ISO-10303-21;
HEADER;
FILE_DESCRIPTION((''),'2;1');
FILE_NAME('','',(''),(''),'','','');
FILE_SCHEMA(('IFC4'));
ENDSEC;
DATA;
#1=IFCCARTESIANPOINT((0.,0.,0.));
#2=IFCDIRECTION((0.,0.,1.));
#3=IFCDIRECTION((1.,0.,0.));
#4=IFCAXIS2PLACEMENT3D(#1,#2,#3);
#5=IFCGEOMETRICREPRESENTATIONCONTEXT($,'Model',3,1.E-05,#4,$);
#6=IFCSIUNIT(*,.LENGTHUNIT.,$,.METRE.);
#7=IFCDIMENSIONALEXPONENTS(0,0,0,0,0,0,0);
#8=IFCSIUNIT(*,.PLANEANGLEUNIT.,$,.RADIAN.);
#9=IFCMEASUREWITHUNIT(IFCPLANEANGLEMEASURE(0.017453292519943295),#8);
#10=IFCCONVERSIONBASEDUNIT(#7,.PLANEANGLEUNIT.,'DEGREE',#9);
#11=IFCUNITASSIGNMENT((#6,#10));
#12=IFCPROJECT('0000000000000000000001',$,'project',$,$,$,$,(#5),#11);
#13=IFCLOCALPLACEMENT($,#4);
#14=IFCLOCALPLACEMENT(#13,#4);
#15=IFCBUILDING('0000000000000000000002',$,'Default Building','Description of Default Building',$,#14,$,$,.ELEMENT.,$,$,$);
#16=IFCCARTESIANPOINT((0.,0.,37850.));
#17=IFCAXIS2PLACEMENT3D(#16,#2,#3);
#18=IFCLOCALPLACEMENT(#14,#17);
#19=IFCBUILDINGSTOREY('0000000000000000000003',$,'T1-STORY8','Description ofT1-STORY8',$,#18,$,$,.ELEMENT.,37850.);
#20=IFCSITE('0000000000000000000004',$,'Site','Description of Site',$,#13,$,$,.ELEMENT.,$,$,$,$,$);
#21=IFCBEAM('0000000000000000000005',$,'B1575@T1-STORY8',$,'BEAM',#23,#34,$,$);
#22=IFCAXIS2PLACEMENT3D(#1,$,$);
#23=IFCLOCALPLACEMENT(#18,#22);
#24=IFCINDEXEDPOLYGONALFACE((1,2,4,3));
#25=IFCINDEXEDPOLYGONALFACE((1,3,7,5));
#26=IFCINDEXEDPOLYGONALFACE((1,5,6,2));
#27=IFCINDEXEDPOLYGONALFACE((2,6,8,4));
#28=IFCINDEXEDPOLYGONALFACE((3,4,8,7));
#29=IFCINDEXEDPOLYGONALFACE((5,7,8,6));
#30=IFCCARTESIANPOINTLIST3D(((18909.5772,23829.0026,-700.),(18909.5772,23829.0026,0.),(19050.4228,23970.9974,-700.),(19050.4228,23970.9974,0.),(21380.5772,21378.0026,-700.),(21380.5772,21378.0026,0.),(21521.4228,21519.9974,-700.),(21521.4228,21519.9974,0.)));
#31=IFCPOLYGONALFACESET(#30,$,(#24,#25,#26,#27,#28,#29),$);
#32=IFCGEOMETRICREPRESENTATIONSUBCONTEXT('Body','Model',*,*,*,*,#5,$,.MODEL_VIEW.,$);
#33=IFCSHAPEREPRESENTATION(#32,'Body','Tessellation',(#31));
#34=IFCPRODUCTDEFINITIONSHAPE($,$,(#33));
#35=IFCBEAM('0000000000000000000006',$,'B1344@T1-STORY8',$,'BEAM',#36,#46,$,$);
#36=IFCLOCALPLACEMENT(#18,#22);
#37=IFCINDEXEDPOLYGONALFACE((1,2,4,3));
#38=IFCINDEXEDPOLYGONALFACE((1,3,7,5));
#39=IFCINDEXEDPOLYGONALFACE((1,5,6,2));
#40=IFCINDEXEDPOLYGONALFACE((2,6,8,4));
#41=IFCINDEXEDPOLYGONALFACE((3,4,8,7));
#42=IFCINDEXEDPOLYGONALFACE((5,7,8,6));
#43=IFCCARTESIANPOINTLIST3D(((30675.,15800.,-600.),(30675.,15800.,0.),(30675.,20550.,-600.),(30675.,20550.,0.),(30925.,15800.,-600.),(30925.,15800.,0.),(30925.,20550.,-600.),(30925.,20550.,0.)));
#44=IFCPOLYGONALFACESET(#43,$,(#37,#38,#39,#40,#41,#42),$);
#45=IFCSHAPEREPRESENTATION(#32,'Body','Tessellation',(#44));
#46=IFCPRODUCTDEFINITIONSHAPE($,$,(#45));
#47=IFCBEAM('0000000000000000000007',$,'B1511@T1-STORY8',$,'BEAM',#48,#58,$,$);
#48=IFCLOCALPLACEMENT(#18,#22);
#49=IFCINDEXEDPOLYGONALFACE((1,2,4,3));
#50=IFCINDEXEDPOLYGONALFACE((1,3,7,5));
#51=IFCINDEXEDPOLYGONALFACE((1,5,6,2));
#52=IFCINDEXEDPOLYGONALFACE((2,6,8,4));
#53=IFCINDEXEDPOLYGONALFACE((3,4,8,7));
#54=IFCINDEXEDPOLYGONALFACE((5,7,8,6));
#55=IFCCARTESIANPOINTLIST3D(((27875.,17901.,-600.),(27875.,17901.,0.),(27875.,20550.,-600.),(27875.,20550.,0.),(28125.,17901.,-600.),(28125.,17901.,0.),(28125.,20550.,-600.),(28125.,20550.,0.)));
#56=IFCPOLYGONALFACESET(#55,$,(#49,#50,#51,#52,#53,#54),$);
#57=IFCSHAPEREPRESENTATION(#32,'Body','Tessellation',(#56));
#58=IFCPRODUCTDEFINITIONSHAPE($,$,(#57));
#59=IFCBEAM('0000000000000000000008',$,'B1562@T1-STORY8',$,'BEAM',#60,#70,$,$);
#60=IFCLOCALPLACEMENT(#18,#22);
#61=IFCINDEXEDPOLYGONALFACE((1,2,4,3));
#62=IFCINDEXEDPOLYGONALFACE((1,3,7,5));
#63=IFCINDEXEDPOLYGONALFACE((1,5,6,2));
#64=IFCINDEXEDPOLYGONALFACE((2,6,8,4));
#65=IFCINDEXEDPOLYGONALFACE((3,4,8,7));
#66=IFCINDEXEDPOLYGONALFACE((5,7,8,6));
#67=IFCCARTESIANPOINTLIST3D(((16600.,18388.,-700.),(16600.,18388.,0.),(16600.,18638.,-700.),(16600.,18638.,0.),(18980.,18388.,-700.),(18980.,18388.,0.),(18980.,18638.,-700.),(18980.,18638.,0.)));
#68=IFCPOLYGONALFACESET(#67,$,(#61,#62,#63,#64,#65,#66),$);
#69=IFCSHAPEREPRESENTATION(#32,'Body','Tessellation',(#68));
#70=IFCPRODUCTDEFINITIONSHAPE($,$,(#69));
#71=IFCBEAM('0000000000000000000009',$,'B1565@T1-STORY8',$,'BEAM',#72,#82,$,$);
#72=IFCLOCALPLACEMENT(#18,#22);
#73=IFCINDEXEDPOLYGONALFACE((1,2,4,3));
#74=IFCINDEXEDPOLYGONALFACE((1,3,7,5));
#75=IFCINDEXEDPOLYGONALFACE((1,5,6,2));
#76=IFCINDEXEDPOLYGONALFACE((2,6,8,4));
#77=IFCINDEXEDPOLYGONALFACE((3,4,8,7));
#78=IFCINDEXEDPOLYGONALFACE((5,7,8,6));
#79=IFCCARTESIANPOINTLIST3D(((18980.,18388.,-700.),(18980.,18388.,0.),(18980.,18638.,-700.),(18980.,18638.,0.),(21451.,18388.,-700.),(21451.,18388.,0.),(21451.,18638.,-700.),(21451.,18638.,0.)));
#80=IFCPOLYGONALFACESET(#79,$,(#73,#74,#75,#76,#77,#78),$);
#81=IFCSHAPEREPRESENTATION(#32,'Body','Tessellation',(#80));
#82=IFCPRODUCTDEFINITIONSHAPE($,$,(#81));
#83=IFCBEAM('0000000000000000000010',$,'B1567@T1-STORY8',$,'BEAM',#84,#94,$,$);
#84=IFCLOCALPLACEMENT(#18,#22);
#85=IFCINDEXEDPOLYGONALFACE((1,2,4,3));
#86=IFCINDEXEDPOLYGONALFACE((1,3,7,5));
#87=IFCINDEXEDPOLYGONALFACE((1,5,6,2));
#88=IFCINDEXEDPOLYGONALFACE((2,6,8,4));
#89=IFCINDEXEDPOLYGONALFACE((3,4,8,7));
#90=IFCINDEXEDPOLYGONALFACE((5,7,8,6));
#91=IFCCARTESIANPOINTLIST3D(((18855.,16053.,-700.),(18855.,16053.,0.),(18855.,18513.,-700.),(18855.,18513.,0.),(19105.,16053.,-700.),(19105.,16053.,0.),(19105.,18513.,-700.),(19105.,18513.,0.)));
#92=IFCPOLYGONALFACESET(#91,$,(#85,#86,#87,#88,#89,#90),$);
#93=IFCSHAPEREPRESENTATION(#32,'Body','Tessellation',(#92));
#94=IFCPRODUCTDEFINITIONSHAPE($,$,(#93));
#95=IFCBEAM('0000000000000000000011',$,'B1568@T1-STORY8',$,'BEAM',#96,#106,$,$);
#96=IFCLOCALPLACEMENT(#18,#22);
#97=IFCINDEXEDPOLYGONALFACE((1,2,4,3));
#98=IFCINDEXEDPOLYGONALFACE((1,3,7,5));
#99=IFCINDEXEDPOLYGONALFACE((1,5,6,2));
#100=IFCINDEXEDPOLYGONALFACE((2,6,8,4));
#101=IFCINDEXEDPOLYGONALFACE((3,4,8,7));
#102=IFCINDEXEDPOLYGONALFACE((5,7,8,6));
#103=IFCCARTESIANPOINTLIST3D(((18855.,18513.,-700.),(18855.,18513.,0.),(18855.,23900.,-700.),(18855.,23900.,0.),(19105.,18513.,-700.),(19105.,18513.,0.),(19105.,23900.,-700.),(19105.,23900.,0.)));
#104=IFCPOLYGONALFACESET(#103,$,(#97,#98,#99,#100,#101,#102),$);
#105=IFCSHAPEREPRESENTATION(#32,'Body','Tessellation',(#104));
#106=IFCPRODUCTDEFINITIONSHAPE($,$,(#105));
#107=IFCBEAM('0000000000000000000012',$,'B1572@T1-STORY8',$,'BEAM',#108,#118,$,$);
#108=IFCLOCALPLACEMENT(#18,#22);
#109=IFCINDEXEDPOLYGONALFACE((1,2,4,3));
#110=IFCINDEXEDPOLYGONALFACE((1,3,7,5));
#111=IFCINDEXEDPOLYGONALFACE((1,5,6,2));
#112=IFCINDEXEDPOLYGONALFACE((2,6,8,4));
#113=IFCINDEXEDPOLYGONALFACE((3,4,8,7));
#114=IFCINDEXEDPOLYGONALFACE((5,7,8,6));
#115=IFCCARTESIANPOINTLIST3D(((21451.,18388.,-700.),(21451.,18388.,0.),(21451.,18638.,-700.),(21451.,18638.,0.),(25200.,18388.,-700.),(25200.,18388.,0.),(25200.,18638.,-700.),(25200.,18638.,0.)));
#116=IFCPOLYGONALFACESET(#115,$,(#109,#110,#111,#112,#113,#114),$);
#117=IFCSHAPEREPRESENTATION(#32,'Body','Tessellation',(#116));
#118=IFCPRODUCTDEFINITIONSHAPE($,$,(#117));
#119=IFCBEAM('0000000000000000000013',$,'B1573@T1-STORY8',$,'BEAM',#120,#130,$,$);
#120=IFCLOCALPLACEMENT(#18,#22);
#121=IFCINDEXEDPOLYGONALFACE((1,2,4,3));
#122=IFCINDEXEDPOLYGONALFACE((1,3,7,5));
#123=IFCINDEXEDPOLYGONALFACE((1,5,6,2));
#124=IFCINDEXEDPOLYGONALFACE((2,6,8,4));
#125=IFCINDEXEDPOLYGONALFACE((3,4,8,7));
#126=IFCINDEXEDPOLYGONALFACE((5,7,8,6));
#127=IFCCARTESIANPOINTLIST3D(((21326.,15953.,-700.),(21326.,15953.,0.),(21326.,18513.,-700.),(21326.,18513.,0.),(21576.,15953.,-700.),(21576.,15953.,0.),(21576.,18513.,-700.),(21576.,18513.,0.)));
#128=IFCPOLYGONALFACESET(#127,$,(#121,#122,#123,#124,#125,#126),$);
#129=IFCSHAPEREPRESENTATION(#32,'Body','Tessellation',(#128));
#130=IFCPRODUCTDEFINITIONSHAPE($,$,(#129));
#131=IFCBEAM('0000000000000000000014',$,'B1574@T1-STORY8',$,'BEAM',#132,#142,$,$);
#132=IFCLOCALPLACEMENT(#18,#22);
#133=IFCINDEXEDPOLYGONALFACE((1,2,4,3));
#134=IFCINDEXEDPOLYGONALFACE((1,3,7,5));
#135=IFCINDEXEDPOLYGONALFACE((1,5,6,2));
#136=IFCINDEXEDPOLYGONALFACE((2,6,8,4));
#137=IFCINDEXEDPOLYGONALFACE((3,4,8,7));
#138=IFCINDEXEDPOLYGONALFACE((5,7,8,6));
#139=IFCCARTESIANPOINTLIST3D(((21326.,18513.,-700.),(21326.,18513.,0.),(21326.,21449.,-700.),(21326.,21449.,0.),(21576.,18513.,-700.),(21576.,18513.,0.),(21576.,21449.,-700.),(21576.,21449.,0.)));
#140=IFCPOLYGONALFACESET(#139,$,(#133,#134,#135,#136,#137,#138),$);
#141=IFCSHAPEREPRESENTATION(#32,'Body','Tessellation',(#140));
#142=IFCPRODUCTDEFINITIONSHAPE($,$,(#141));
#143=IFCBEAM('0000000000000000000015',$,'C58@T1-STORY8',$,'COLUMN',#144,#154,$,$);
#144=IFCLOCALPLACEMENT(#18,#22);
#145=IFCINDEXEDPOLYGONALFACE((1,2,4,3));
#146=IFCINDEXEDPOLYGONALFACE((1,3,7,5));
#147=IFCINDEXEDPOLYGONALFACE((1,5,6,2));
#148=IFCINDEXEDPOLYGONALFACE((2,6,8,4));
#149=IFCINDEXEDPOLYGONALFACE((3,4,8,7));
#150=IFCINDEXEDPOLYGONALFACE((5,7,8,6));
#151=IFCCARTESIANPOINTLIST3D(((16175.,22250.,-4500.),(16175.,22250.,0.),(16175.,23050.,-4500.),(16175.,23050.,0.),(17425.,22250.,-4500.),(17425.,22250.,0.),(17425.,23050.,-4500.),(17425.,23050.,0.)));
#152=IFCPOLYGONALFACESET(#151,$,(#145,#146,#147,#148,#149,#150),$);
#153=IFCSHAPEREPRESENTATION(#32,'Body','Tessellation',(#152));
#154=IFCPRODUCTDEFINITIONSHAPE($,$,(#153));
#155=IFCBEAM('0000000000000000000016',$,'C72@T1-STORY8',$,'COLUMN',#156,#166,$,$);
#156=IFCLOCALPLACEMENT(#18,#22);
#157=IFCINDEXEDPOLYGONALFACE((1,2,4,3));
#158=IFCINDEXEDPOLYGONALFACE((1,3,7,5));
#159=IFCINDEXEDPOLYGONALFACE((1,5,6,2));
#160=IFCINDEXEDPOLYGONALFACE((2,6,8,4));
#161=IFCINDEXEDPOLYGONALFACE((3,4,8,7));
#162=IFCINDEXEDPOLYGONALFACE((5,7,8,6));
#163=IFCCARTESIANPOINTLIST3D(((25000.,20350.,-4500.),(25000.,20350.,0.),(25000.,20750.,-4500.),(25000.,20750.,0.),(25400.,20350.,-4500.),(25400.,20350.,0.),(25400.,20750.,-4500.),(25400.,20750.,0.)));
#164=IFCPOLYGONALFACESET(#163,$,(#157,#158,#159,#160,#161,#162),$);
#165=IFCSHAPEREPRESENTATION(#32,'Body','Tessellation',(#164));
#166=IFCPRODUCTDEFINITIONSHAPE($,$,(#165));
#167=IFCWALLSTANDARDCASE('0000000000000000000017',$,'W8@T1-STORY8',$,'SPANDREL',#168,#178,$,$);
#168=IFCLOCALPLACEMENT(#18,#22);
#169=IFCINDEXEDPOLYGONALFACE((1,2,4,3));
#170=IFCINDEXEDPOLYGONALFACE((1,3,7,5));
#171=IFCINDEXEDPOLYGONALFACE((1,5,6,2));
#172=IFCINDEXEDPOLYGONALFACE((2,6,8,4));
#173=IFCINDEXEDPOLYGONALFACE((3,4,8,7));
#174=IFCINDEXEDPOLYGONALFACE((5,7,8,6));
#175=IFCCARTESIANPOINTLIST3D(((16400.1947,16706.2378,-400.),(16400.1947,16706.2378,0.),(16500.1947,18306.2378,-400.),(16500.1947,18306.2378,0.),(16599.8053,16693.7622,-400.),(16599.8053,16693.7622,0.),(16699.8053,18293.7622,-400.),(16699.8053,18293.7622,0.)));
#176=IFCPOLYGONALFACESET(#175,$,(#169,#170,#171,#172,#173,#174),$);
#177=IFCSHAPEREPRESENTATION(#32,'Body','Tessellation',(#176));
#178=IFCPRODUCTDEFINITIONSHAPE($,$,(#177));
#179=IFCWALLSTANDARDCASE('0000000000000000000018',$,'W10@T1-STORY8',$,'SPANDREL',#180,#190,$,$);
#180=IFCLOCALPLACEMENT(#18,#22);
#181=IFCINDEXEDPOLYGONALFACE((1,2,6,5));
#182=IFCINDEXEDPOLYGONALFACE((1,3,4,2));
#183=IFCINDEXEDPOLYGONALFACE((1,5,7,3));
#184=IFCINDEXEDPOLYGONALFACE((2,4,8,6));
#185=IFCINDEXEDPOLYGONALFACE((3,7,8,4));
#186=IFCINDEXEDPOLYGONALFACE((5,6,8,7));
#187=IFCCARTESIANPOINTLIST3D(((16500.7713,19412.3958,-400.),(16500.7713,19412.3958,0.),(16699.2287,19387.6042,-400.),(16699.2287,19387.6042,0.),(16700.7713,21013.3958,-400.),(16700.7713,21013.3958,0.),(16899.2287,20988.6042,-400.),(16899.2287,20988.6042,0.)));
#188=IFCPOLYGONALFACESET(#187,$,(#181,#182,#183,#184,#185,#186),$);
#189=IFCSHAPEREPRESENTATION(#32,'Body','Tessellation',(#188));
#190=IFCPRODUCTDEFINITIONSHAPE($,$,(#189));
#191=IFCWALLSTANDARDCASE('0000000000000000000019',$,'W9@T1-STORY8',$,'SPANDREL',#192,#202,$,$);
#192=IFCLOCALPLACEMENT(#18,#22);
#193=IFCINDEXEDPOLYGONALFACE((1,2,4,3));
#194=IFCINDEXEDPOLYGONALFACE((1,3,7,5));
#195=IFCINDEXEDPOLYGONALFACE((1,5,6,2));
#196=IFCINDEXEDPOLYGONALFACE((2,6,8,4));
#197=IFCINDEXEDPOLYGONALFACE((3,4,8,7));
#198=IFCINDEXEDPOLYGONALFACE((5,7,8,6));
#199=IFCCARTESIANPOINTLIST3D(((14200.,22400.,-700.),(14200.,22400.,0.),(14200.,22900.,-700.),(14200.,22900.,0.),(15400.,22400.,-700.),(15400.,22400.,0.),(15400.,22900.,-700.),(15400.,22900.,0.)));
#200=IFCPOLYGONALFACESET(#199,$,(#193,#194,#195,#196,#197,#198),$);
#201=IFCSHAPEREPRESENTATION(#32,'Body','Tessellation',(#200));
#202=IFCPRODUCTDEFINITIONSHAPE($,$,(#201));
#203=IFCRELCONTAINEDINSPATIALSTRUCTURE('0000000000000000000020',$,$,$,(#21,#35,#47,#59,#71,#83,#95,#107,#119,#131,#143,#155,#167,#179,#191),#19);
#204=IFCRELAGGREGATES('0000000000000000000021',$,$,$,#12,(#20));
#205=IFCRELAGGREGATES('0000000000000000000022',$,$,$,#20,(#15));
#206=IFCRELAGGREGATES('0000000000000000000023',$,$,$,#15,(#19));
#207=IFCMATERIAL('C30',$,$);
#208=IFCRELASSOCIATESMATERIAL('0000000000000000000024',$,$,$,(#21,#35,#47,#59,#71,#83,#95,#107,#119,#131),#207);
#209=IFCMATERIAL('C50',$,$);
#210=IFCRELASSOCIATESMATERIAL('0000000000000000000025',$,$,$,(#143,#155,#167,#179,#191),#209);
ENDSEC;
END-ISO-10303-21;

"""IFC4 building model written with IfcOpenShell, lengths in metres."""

from ifc_helpers import new_model, entity, si_unit, converted_unit, frame, origin_with_axes, place, context, subcontext, project, spatial, indexed_curve, rectangle, outline, extrude, material, element, save


model = new_model("IFC4")

# Units and contexts
model_context = context("Model", 3, precision=1e-05, world=origin_with_axes())
body_context = subcontext(model_context, "Body", "Model", "MODEL_VIEW")
ifc_project = project(units=[si_unit("LENGTHUNIT", "METRE"), converted_unit("PLANEANGLEUNIT", "DEGREE", entity("IfcPlaneAngleMeasure", 0.017453292519943295), si_unit("PLANEANGLEUNIT", "RADIAN"), dimensions=[0, 0, 0, 0, 0, 0, 0])], contexts=[model_context])

# Site, building, storey
site_placement = place(None, origin_with_axes())
site = spatial("IfcSite", under=ifc_project, at=site_placement, Name="Site", Description="Description of Site", CompositionType="ELEMENT")
building_placement = place(site_placement, origin_with_axes())
building = spatial("IfcBuilding", under=site, at=building_placement, Name="Default Building", Description="Description of Default Building", CompositionType="ELEMENT")
storey_placement = place(building_placement, frame((0.0, 0.0, 37850.0), z_axis=(0.0, 0.0, 1.0), x_axis=(1.0, 0.0, 0.0)))
storey = spatial("IfcBuildingStorey", under=building, at=storey_placement, Name="T1-STORY8", Description="Description ofT1-STORY8", CompositionType="ELEMENT", Elevation=37850.0)

# Beams
ifc_material_1 = material(Name="C30")
beam_1_placement = place(storey_placement, frame((18980.0, 23900.0, -350.0), z_axis=(0.709974, -0.704228, 0.0), x_axis=(0.704228, 0.709974, 0.0)))
element("IfcBeam", 1, at=beam_1_placement, inside=storey, material=ifc_material_1, Name="B1575@T1-STORY8", ObjectType="BEAM", context=body_context, shape_type="SweptSolid", body=[
    extrude(rectangle(XDim=200.0, YDim=700.0), origin_with_axes(), (0.0, 0.0, 1.0), 3480.4083),
])
beam_2_placement = place(storey_placement, frame((30800.0, 15800.0, -300.0), z_axis=(0.0, 1.0, 0.0), x_axis=(-1.0, 0.0, 0.0)))
element("IfcBeam", 2, at=beam_2_placement, inside=storey, material=ifc_material_1, Name="B1344@T1-STORY8", ObjectType="BEAM", context=body_context, shape_type="SweptSolid", body=[
    extrude(rectangle(XDim=250.0, YDim=600.0), origin_with_axes(), (0.0, 0.0, 1.0), 4750.0),
])
beam_3_placement = place(storey_placement, frame((28000.0, 17901.0, -300.0), z_axis=(0.0, 1.0, 0.0), x_axis=(-1.0, 0.0, 0.0)))
element("IfcBeam", 3, at=beam_3_placement, inside=storey, material=ifc_material_1, Name="B1511@T1-STORY8", ObjectType="BEAM", context=body_context, shape_type="SweptSolid", body=[
    extrude(rectangle(XDim=250.0, YDim=600.0), origin_with_axes(), (0.0, 0.0, 1.0), 2649.0),
])
beam_4_placement = place(storey_placement, frame((16600.0, 18513.0, -350.0), z_axis=(1.0, 0.0, 0.0), x_axis=(0.0, 1.0, 0.0)))
element("IfcBeam", 4, at=beam_4_placement, inside=storey, material=ifc_material_1, Name="B1562@T1-STORY8", ObjectType="BEAM", context=body_context, shape_type="SweptSolid", body=[
    extrude(rectangle(XDim=250.0, YDim=700.0), origin_with_axes(), (0.0, 0.0, 1.0), 2380.0),
])
beam_5_placement = place(storey_placement, frame((18980.0, 18513.0, -350.0), z_axis=(1.0, 0.0, 0.0), x_axis=(0.0, 1.0, 0.0)))
element("IfcBeam", 5, at=beam_5_placement, inside=storey, material=ifc_material_1, Name="B1565@T1-STORY8", ObjectType="BEAM", context=body_context, shape_type="SweptSolid", body=[
    extrude(rectangle(XDim=250.0, YDim=700.0), origin_with_axes(), (0.0, 0.0, 1.0), 2471.0),
])
beam_6_placement = place(storey_placement, frame((18980.0, 16053.0, -350.0), z_axis=(0.0, 1.0, 0.0), x_axis=(-1.0, 0.0, 0.0)))
element("IfcBeam", 6, at=beam_6_placement, inside=storey, material=ifc_material_1, Name="B1567@T1-STORY8", ObjectType="BEAM", context=body_context, shape_type="SweptSolid", body=[
    extrude(rectangle(XDim=250.0, YDim=700.0), origin_with_axes(), (0.0, 0.0, 1.0), 2460.0),
])
beam_7_placement = place(storey_placement, frame((18980.0, 18513.0, -350.0), z_axis=(0.0, 1.0, 0.0), x_axis=(-1.0, 0.0, 0.0)))
element("IfcBeam", 7, at=beam_7_placement, inside=storey, material=ifc_material_1, Name="B1568@T1-STORY8", ObjectType="BEAM", context=body_context, shape_type="SweptSolid", body=[
    extrude(rectangle(XDim=250.0, YDim=700.0), origin_with_axes(), (0.0, 0.0, 1.0), 5387.0),
])
beam_8_placement = place(storey_placement, frame((21451.0, 18513.0, -350.0), z_axis=(1.0, 0.0, 0.0), x_axis=(0.0, 1.0, 0.0)))
element("IfcBeam", 8, at=beam_8_placement, inside=storey, material=ifc_material_1, Name="B1572@T1-STORY8", ObjectType="BEAM", context=body_context, shape_type="SweptSolid", body=[
    extrude(rectangle(XDim=250.0, YDim=700.0), origin_with_axes(), (0.0, 0.0, 1.0), 3749.0),
])
beam_9_placement = place(storey_placement, frame((21451.0, 15953.0, -350.0), z_axis=(0.0, 1.0, 0.0), x_axis=(-1.0, 0.0, 0.0)))
element("IfcBeam", 9, at=beam_9_placement, inside=storey, material=ifc_material_1, Name="B1573@T1-STORY8", ObjectType="BEAM", context=body_context, shape_type="SweptSolid", body=[
    extrude(rectangle(XDim=250.0, YDim=700.0), origin_with_axes(), (0.0, 0.0, 1.0), 2560.0),
])
beam_10_placement = place(storey_placement, frame((21451.0, 18513.0, -350.0), z_axis=(0.0, 1.0, 0.0), x_axis=(-1.0, 0.0, 0.0)))
element("IfcBeam", 10, at=beam_10_placement, inside=storey, material=ifc_material_1, Name="B1574@T1-STORY8", ObjectType="BEAM", context=body_context, shape_type="SweptSolid", body=[
    extrude(rectangle(XDim=250.0, YDim=700.0), origin_with_axes(), (0.0, 0.0, 1.0), 2936.0),
])
ifc_material_2 = material(Name="C50")
beam_11_placement = place(storey_placement, frame((16800.0, 22650.0, -4500.0), z_axis=(0.0, 0.0, 1.0), x_axis=(0.0, -1.0, 0.0)))
element("IfcBeam", 11, at=beam_11_placement, inside=storey, material=ifc_material_2, Name="C58@T1-STORY8", ObjectType="COLUMN", context=body_context, shape_type="SweptSolid", body=[
    extrude(rectangle(XDim=800.0, YDim=1250.0), origin_with_axes(), (0.0, 0.0, 1.0), 4500.0),
])
beam_12_placement = place(storey_placement, frame((25200.0, 20550.0, -4500.0), z_axis=(0.0, 0.0, 1.0), x_axis=(-1.0, 0.0, 0.0)))
element("IfcBeam", 12, at=beam_12_placement, inside=storey, material=ifc_material_2, Name="C72@T1-STORY8", ObjectType="COLUMN", context=body_context, shape_type="SweptSolid", body=[
    extrude(rectangle(XDim=400.0, YDim=400.0), origin_with_axes(), (0.0, 0.0, 1.0), 4500.0),
])

# Walls
wall_1_placement = place(storey_placement, frame((16500.0, 16700.0, -400.0), z_axis=(0.0, 0.0, 1.0), x_axis=(0.062378, 0.998053, 0.0)))
element("IfcWallStandardCase", 13, at=wall_1_placement, inside=storey, material=ifc_material_2, Name="W8@T1-STORY8", ObjectType="SPANDREL", context=body_context, shape_type="SweptSolid", body=[
    extrude(outline(indexed_curve([(0.0, -100.0), (0.0, 100.0), (1603.122, 100.0), (1603.122, -100.0), (0.0, -100.0)], self_intersect=False)), origin_with_axes(), (0.0, 0.0, 1.0), 400.0),
])
wall_2_placement = place(storey_placement, frame((16600.0, 19400.0, -400.0), z_axis=(0.0, 0.0, 1.0), x_axis=(0.123958, 0.992287, 0.0)))
element("IfcWallStandardCase", 14, at=wall_2_placement, inside=storey, material=ifc_material_2, Name="W10@T1-STORY8", ObjectType="SPANDREL", context=body_context, shape_type="SweptSolid", body=[
    extrude(outline(indexed_curve([(0.0, -100.0), (0.0, 100.0), (1613.4438, 100.0), (1613.4438, -100.0), (0.0, -100.0)], self_intersect=False)), origin_with_axes(), (0.0, 0.0, 1.0), 400.0),
])
wall_3_placement = place(storey_placement, frame((14200.0, 22650.0, -700.0), z_axis=(0.0, 0.0, 1.0), x_axis=(1.0, 0.0, 0.0)))
element("IfcWallStandardCase", 15, at=wall_3_placement, inside=storey, material=ifc_material_2, Name="W9@T1-STORY8", ObjectType="SPANDREL", context=body_context, shape_type="SweptSolid", body=[
    extrude(outline(indexed_curve([(0.0, -250.0), (0.0, 250.0), (1200.0, 250.0), (1200.0, -250.0), (0.0, -250.0)], self_intersect=False)), origin_with_axes(), (0.0, 0.0, 1.0), 700.0),
])

save(model, "model.ifc")
